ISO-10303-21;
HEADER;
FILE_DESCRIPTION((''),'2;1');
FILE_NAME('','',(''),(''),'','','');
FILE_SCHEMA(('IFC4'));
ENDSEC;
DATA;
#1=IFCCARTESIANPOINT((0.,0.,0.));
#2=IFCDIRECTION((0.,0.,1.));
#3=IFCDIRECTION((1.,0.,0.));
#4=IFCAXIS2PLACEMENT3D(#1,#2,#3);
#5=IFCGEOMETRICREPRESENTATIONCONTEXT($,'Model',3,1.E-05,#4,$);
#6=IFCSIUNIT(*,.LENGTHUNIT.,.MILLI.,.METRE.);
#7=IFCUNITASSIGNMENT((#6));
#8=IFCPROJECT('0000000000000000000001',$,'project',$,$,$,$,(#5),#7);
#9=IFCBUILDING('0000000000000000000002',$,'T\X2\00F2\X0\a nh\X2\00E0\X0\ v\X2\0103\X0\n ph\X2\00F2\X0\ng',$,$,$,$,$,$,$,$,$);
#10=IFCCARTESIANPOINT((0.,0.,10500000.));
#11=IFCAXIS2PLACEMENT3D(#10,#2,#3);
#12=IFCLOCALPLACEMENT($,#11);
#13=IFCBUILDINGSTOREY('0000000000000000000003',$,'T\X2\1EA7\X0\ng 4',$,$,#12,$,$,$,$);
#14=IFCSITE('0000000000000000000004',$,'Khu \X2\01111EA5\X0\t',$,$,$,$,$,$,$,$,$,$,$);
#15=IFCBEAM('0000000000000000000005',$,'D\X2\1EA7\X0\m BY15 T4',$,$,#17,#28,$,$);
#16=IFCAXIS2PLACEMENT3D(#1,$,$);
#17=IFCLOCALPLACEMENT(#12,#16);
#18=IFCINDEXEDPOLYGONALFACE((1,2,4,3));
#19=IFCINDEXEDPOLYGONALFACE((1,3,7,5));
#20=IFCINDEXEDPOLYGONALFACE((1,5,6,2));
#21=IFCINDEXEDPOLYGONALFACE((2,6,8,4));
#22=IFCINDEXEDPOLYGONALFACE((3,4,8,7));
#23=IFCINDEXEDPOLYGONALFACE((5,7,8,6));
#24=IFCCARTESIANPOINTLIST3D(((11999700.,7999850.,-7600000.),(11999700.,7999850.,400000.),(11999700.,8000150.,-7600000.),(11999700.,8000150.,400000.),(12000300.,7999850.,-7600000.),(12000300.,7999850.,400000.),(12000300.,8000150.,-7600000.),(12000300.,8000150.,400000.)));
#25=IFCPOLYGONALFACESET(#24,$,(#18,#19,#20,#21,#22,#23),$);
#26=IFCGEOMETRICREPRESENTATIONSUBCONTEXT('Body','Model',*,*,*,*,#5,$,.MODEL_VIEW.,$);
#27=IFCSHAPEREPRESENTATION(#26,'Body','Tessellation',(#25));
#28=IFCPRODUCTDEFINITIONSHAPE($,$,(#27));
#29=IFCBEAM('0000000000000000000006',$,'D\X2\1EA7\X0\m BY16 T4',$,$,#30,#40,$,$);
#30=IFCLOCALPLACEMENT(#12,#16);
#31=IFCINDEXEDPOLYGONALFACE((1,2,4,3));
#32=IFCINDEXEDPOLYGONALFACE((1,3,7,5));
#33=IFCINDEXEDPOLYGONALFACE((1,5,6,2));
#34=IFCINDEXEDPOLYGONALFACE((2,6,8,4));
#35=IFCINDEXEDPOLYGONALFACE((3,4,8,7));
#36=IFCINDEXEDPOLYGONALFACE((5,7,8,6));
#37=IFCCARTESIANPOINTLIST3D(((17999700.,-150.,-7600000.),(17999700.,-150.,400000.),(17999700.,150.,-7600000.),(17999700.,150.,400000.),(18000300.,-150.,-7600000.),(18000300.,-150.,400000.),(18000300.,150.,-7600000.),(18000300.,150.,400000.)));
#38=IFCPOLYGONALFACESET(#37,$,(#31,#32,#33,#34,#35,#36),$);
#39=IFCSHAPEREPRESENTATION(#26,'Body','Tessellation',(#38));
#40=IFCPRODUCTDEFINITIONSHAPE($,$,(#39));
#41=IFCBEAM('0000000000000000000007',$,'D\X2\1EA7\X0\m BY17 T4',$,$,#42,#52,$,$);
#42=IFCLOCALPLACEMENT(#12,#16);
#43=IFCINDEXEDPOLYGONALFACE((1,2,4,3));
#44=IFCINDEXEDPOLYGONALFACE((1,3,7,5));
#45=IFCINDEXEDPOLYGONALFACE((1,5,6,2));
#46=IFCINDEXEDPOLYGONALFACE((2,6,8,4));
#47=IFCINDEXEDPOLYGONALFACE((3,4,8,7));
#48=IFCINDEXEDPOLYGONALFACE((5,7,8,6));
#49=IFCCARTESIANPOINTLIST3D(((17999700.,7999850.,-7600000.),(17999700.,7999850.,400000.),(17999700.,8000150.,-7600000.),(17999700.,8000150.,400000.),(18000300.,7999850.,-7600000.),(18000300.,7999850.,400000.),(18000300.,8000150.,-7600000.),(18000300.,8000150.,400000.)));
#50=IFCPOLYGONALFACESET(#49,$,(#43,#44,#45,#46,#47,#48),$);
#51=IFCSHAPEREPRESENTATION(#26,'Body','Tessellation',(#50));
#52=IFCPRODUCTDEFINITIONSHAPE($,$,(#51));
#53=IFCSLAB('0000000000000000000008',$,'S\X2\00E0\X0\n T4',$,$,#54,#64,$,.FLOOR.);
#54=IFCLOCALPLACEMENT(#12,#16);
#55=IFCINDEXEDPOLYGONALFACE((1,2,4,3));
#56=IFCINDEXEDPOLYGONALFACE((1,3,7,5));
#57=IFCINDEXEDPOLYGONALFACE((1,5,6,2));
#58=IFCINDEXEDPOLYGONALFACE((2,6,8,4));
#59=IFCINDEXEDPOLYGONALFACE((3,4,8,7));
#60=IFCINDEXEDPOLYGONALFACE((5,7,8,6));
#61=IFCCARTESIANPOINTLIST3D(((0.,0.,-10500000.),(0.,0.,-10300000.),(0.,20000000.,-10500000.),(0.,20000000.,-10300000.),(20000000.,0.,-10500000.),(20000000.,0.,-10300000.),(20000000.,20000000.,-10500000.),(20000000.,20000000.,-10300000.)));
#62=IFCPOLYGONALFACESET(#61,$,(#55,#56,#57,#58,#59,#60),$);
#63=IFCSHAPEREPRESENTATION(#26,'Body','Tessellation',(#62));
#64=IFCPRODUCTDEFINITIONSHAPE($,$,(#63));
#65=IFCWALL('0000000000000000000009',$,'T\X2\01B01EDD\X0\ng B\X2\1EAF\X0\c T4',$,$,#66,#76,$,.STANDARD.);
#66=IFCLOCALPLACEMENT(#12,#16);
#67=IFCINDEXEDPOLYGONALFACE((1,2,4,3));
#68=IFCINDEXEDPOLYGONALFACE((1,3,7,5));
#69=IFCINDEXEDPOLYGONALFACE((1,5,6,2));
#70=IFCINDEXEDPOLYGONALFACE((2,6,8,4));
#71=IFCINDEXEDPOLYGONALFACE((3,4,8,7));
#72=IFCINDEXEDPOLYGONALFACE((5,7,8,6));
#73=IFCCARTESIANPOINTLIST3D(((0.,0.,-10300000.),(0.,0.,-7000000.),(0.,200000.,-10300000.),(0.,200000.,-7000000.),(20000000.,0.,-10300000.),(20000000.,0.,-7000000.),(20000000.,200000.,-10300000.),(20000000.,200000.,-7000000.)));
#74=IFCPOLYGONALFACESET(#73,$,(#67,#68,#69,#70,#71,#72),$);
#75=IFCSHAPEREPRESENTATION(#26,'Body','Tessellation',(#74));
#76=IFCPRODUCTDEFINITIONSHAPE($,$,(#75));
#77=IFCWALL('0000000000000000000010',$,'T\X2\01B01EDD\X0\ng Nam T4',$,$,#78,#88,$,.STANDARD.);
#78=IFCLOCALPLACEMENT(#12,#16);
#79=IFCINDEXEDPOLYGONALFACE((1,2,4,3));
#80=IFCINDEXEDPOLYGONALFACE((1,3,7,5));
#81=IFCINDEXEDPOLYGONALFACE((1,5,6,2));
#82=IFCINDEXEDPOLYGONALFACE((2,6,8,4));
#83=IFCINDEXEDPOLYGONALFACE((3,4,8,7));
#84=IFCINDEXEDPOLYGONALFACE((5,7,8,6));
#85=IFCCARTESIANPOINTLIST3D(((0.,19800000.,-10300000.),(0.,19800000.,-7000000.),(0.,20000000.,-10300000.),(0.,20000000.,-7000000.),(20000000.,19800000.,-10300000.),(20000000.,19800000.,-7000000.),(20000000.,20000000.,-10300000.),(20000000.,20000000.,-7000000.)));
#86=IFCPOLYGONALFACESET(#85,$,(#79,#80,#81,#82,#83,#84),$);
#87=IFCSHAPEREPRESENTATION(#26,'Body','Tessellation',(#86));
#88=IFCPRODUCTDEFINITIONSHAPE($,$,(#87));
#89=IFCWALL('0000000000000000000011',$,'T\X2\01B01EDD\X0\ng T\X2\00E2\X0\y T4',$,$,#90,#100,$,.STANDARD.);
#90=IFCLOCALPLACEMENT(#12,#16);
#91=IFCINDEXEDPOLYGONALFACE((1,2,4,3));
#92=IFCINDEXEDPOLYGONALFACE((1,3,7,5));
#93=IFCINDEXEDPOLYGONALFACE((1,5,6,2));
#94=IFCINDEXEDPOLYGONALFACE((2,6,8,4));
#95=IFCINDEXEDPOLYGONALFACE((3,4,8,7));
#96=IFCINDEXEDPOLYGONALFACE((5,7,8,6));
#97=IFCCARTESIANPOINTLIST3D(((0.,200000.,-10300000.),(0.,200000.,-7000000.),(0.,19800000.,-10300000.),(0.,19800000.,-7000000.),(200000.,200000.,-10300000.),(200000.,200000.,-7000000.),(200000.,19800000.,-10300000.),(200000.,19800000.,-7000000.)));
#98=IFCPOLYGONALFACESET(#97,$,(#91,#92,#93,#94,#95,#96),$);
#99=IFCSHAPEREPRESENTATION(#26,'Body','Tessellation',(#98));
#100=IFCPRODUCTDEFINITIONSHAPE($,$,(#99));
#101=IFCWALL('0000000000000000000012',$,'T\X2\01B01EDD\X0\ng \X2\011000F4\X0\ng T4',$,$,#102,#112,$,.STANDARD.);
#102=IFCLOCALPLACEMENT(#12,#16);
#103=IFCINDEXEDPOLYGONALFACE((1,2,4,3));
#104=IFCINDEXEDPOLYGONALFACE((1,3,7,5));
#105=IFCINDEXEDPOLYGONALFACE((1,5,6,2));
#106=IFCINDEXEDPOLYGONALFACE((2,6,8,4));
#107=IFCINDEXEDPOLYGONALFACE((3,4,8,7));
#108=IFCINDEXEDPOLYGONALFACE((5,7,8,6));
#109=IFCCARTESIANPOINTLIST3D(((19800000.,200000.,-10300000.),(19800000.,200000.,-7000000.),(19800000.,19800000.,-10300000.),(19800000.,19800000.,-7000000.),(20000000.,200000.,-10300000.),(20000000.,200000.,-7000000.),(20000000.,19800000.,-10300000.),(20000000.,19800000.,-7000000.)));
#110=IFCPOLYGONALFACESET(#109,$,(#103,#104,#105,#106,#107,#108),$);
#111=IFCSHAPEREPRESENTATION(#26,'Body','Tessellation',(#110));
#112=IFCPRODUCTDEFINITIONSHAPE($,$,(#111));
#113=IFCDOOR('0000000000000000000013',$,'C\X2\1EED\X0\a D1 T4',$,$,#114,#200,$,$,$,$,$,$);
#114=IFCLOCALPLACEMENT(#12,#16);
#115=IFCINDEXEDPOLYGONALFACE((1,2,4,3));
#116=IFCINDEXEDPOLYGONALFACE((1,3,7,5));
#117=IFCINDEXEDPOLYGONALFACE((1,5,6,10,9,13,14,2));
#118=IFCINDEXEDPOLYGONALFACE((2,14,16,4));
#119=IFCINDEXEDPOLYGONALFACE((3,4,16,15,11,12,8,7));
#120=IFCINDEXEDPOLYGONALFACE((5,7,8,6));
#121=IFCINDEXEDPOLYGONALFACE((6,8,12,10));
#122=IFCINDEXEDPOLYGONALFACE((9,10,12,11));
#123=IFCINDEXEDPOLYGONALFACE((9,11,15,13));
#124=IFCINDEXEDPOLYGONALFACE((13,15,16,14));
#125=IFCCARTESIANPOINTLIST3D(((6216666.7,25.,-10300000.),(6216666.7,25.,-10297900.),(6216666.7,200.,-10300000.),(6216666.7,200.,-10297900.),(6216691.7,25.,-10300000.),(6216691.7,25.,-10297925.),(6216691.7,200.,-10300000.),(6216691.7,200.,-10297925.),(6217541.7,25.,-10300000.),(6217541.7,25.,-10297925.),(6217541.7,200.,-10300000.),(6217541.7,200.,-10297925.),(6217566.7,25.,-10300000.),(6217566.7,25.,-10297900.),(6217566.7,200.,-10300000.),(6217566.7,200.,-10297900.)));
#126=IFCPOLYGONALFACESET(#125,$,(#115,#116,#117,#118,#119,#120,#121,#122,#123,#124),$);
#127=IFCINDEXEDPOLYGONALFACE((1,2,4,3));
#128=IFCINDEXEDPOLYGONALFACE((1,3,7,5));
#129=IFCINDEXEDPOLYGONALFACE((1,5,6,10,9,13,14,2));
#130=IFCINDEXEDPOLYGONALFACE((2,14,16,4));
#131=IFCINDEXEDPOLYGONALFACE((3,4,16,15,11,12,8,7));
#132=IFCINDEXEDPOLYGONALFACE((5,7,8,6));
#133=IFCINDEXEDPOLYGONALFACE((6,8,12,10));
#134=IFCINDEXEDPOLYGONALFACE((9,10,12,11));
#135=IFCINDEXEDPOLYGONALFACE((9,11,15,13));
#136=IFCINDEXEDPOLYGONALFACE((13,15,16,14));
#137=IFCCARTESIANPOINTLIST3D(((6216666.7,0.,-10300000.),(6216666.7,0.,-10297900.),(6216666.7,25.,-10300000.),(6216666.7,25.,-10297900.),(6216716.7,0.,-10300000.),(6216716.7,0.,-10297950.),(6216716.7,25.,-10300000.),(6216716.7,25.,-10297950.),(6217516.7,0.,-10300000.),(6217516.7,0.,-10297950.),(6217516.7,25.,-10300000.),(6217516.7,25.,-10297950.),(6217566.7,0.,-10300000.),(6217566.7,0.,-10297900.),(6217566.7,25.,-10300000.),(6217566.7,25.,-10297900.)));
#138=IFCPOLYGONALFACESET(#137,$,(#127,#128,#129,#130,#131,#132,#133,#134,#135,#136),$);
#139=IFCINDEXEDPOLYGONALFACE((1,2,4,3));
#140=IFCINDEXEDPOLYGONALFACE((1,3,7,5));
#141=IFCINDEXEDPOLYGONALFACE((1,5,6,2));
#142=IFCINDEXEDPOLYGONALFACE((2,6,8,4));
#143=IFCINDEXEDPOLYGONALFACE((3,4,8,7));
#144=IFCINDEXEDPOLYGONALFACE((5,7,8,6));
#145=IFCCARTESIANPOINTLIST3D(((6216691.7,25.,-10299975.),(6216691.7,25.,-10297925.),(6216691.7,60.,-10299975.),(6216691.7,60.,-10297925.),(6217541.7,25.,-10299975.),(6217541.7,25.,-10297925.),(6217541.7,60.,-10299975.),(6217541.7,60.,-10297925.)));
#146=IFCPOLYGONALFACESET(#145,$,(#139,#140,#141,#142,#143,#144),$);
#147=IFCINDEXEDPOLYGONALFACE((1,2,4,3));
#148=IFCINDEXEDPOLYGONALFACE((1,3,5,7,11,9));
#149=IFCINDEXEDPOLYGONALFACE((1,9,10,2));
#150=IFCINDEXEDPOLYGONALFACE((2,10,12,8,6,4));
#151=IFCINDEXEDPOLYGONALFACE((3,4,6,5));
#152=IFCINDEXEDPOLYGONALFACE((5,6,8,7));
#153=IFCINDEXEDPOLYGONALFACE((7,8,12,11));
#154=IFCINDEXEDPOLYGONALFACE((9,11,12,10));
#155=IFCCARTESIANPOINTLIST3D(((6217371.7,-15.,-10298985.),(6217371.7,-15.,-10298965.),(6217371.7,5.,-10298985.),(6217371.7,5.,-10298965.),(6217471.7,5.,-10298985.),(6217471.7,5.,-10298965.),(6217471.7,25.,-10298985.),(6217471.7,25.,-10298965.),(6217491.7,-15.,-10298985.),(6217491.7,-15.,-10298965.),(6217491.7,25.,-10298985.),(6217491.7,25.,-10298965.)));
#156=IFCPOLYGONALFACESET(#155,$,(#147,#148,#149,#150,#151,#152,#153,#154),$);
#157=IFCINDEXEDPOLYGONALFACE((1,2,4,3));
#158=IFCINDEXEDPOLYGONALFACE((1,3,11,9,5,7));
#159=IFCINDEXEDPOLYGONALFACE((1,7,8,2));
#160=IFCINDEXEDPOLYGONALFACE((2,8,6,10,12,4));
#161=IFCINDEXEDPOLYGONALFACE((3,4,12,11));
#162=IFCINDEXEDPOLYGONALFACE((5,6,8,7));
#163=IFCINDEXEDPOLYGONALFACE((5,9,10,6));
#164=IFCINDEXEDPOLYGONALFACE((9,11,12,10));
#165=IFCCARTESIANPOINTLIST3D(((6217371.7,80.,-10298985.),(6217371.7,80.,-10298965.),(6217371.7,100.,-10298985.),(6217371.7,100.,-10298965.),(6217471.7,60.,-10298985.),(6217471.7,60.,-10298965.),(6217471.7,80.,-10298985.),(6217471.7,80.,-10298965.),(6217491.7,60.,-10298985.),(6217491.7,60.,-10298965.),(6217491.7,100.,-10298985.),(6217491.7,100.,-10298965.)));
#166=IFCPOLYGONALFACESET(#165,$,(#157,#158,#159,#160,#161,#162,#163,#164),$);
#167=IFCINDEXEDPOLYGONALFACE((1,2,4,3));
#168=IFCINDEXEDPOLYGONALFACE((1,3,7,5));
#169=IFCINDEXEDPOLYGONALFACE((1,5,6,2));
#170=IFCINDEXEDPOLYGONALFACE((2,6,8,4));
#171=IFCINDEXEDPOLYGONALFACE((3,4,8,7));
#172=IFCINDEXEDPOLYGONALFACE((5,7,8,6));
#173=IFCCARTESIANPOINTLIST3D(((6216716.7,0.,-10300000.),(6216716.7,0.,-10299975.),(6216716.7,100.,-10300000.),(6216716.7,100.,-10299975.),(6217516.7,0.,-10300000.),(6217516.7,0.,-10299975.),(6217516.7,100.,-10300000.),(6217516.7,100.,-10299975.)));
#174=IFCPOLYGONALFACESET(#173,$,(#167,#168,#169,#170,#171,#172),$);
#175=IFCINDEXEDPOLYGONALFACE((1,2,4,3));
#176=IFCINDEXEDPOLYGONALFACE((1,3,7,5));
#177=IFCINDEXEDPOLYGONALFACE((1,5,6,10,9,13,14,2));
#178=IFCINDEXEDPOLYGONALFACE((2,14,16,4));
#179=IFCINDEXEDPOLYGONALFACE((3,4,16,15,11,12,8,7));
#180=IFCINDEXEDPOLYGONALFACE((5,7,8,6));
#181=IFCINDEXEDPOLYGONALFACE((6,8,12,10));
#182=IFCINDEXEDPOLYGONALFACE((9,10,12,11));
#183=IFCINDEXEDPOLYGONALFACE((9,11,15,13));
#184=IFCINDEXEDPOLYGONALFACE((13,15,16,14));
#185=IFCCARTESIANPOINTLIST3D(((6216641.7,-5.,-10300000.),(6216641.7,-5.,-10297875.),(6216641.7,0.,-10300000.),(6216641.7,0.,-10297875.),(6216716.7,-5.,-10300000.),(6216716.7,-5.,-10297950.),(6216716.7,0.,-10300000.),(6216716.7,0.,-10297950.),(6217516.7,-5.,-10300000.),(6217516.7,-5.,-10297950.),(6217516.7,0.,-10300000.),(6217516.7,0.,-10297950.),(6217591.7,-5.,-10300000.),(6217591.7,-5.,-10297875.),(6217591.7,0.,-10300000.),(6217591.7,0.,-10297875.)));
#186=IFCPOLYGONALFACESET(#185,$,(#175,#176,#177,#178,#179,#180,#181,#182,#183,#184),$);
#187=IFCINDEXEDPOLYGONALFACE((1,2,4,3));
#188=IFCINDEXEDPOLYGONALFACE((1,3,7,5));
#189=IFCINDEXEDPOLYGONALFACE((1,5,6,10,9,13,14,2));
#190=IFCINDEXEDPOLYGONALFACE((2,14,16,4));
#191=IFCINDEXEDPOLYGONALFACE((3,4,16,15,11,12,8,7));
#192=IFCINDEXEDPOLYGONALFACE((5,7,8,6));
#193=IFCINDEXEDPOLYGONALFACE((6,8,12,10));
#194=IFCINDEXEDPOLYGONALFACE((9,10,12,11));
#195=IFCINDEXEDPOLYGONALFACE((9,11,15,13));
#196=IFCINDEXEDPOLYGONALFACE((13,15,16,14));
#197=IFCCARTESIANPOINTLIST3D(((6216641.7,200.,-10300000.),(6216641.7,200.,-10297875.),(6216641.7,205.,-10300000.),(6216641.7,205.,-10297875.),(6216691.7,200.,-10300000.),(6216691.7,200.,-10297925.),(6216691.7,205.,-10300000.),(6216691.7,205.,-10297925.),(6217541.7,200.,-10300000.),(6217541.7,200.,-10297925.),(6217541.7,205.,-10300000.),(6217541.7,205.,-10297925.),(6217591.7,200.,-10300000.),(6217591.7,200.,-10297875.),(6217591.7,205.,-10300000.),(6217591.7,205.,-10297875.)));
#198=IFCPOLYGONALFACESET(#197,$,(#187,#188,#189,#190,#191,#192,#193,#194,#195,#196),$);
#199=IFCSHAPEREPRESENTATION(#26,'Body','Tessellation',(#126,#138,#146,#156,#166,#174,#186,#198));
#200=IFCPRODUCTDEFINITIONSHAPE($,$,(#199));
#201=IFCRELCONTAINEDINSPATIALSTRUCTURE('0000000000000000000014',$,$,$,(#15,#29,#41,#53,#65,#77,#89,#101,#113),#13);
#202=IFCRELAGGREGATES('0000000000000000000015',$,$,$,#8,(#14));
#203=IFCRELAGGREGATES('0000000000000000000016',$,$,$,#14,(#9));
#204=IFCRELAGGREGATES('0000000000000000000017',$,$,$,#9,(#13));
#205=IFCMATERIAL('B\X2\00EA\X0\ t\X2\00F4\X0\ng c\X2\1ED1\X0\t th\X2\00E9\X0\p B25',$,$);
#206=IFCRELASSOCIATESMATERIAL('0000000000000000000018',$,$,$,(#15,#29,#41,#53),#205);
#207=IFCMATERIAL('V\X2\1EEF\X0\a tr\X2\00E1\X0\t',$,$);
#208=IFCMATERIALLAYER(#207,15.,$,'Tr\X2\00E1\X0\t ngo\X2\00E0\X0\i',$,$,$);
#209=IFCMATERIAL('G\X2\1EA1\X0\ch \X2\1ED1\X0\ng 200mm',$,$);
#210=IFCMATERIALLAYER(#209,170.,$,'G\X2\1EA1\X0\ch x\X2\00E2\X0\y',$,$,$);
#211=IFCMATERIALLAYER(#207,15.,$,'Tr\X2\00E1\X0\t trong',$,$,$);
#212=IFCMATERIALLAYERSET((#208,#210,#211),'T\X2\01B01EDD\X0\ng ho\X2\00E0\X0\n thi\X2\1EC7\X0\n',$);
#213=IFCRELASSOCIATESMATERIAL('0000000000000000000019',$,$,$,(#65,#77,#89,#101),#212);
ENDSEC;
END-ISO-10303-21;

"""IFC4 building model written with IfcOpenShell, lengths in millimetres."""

from ifc_helpers import new_model, entity, si_unit, frame, origin_with_axes, place, context, subcontext, project, spatial, line, indexed_curve, outline, extrude, material, layer, layer_set, layer_usage, element, save


model = new_model("IFC4")

# Units and contexts
model_context = context("Model", 3, precision=1e-05, world=origin_with_axes())
body_context = subcontext(model_context, "Body", "Model", "MODEL_VIEW")
ifc_project = project(units=[si_unit("LENGTHUNIT", "METRE", prefix="MILLI")], contexts=[model_context])

# Site, building, storey
site = spatial("IfcSite", under=ifc_project, Name="Khu đất")
building = spatial("IfcBuilding", under=site, Name="Tòa nhà văn phòng")
storey_placement = place(None, frame((0.0, 0.0, 10500000.0), z_axis=(0.0, 0.0, 1.0), x_axis=(1.0, 0.0, 0.0)))
storey = spatial("IfcBuildingStorey", under=building, at=storey_placement, Name="Tầng 4")

# Shared definitions
ifc_material_1 = material(Name="Bê tông cốt thép B25")

# Beams
for number, where, z_axis, x_axis, name in (
    (1, (12000000.0, 8000000.0, -7600000.0), (0.0, 0.0, 1.0), (0.0, 1.0, 0.0), "Dầm BY15 T4"),
    (2, (18000000.0, 0.0, -7600000.0), (0.0, 0.0, 1.0), (0.0, 1.0, 0.0), "Dầm BY16 T4"),
    (3, (18000000.0, 8000000.0, -7600000.0), (0.0, 0.0, 1.0), (0.0, 1.0, 0.0), "Dầm BY17 T4"),
):
    element("IfcBeam", number, at=place(storey_placement, frame(where, z_axis=z_axis, x_axis=x_axis)), inside=storey, material=ifc_material_1, Name=name, context=body_context, shape_type="SweptSolid", body=[
        extrude(entity("IfcRectangleProfileDef", None, None, None, 300.0, 600.0), origin_with_axes(), (0.0, 0.0, 1.0), 8000000.0),
    ])

# Slab
slab_placement = place(storey_placement, frame((0.0, 0.0, -10500000.0), z_axis=(0.0, 0.0, 1.0), x_axis=(1.0, 0.0, 0.0)))
element("IfcSlab", 4, at=slab_placement, inside=storey, material=ifc_material_1, Name="Sàn T4", PredefinedType="FLOOR", context=body_context, shape_type="SweptSolid", body=[
    extrude(outline(indexed_curve([(0.0, 0.0), (20000000.0, 0.0), (20000000.0, 20000000.0), (0.0, 20000000.0), (0.0, 0.0)])), None, (0.0, 0.0, 1.0), 200000.0),
])

# Walls
ifc_material_2 = material(Name="Vữa trát")
ifc_layer_1 = layer(ifc_material_2, 15.0, Name="Trát ngoài")
ifc_material_3 = material(Name="Gạch ống 200mm")
ifc_layer_2 = layer(ifc_material_3, 170.0, Name="Gạch xây")
ifc_layer_3 = layer(ifc_material_2, 15.0, Name="Trát trong")
ifc_layer_set = layer_set([ifc_layer_1, ifc_layer_2, ifc_layer_3], Name="Tường hoàn thiện")
ifc_layer_usage_1 = layer_usage(ifc_layer_set, "AXIS2", "POSITIVE", 0.0)
wall_1_placement = place(storey_placement, frame((0.0, 0.0, -10300000.0), z_axis=(0.0, 0.0, 1.0), x_axis=(1.0, 0.0, 0.0)))
element("IfcWall", 5, at=wall_1_placement, inside=storey, material=ifc_layer_usage_1, Name="Tường Bắc T4", PredefinedType="STANDARD", context=body_context, shape_type="SweptSolid", body=[
    extrude(outline(indexed_curve([(0.0, 0.0), (0.0, 200000.0), (20000000.0, 200000.0), (20000000.0, 0.0), (0.0, 0.0)], self_intersect=False)), origin_with_axes(), (0.0, 0.0, 1.0), 3300000.0),
])
ifc_layer_usage_2 = layer_usage(ifc_layer_set, "AXIS2", "POSITIVE", 0.0)
wall_2_placement = place(storey_placement, frame((0.0, 19800000.0, -10300000.0), z_axis=(0.0, 0.0, 1.0), x_axis=(1.0, 0.0, 0.0)))
element("IfcWall", 6, at=wall_2_placement, inside=storey, material=ifc_layer_usage_2, Name="Tường Nam T4", PredefinedType="STANDARD", context=body_context, shape_type="SweptSolid", body=[
    extrude(outline(indexed_curve([(0.0, 0.0), (0.0, 200000.0), (20000000.0, 200000.0), (20000000.0, 0.0), (0.0, 0.0)], self_intersect=False)), origin_with_axes(), (0.0, 0.0, 1.0), 3300000.0),
])
ifc_layer_usage_3 = layer_usage(ifc_layer_set, "AXIS2", "POSITIVE", 0.0)
wall_3_placement = place(storey_placement, frame((0.0, 200000.0, -10300000.0), z_axis=(0.0, 0.0, 1.0), x_axis=(1.0, 0.0, 0.0)))
element("IfcWall", 7, at=wall_3_placement, inside=storey, material=ifc_layer_usage_3, Name="Tường Tây T4", PredefinedType="STANDARD", context=body_context, shape_type="SweptSolid", body=[
    extrude(outline(indexed_curve([(0.0, 0.0), (0.0, 19600000.0), (200000.0, 19600000.0), (200000.0, 0.0), (0.0, 0.0)], self_intersect=False)), origin_with_axes(), (0.0, 0.0, 1.0), 3300000.0),
])
ifc_layer_usage_4 = layer_usage(ifc_layer_set, "AXIS2", "POSITIVE", 0.0)
wall_4_placement = place(storey_placement, frame((19800000.0, 200000.0, -10300000.0), z_axis=(0.0, 0.0, 1.0), x_axis=(1.0, 0.0, 0.0)))
element("IfcWall", 8, at=wall_4_placement, inside=storey, material=ifc_layer_usage_4, Name="Tường Đông T4", PredefinedType="STANDARD", context=body_context, shape_type="SweptSolid", body=[
    extrude(outline(indexed_curve([(0.0, 0.0), (0.0, 19600000.0), (200000.0, 19600000.0), (200000.0, 0.0), (0.0, 0.0)], self_intersect=False)), origin_with_axes(), (0.0, 0.0, 1.0), 3300000.0),
])

# Door
door_1_placement = place(storey_placement, frame((6216666.7, 0.0, -10300000.0), z_axis=(0.0, 0.0, 1.0), x_axis=(1.0, 0.0, 0.0)))
element("IfcDoor", 9, at=door_1_placement, inside=storey, Name="Cửa D1 T4", context=body_context, shape_type="SolidModel", body=[
    extrude(outline(indexed_curve([(0.0, 0.0), (0.0, 2100.0), (900.0, 2100.0), (900.0, 0.0), (875.0, 0.0), (875.0, 2075.0), (25.0, 2075.0), (25.0, 0.0)], segments=[line(1, 2, 3, 4, 5, 6, 7, 8, 1)])), frame((0.0, 25.0, 0.0), z_axis=(0.0, -1.0, 0.0), x_axis=(1.0, 0.0, 0.0)), (0.0, 0.0, -1.0), 175.0),
    extrude(outline(indexed_curve([(0.0, 0.0), (0.0, 2100.0), (900.0, 2100.0), (900.0, 0.0), (850.0, 0.0), (850.0, 2050.0), (50.0, 2050.0), (50.0, 0.0)], segments=[line(1, 2, 3, 4, 5, 6, 7, 8, 1)])), frame((0.0, 0.0, 0.0), z_axis=(0.0, -1.0, 0.0), x_axis=(1.0, 0.0, 0.0)), (0.0, 0.0, -1.0), 25.0),
    extrude(outline(indexed_curve([(0.0, 0.0), (850.0, 0.0), (850.0, 35.0), (0.0, 35.0)], segments=[line(1, 2, 3, 4, 1)])), frame((25.0, 25.0, 25.0), z_axis=(0.0, 0.0, 1.0), x_axis=(1.0, 0.0, 0.0)), (0.0, 0.0, 1.0), 2050.0),
    extrude(outline(indexed_curve([(0.0, 0.0), (0.0, -40.0), (-120.0, -40.0), (-120.0, -20.0), (-20.0, -20.0), (-20.0, 0.0)], segments=[line(1, 2, 3, 4, 5, 6, 1)])), frame((825.0, 25.0, 1015.0), z_axis=(0.0, 0.0, 1.0), x_axis=(1.0, 0.0, 0.0)), (0.0, 0.0, 1.0), 20.0),
    extrude(outline(indexed_curve([(0.0, 0.0), (0.0, 40.0), (-120.0, 40.0), (-120.0, 20.0), (-20.0, 20.0), (-20.0, 0.0)], segments=[line(1, 2, 3, 4, 5, 6, 1)])), frame((825.0, 60.0, 1015.0), z_axis=(0.0, 0.0, 1.0), x_axis=(1.0, 0.0, 0.0)), (0.0, 0.0, 1.0), 20.0),
    extrude(outline(indexed_curve([(0.0, 0.0), (800.0, 0.0), (800.0, 100.0), (0.0, 100.0)], segments=[line(1, 2, 3, 4, 1)])), frame((50.0, 0.0, 0.0), z_axis=(0.0, 0.0, 1.0), x_axis=(1.0, 0.0, 0.0)), (0.0, 0.0, 1.0), 25.0),
    extrude(outline(indexed_curve([(0.0, 0.0), (0.0, 2125.0), (950.0, 2125.0), (950.0, 0.0), (875.0, 0.0), (875.0, 2050.0), (75.0, 2050.0), (75.0, 0.0)], segments=[line(1, 2, 3, 4, 5, 6, 7, 8, 1)])), frame((-25.0, -5.0, 0.0), z_axis=(0.0, -1.0, 0.0), x_axis=(1.0, 0.0, 0.0)), (0.0, 0.0, -1.0), 5.0),
    extrude(outline(indexed_curve([(0.0, 0.0), (0.0, 2125.0), (950.0, 2125.0), (950.0, 0.0), (900.0, 0.0), (900.0, 2075.0), (50.0, 2075.0), (50.0, 0.0)], segments=[line(1, 2, 3, 4, 5, 6, 7, 8, 1)])), frame((-25.0, 200.0, 0.0), z_axis=(0.0, -1.0, 0.0), x_axis=(1.0, 0.0, 0.0)), (0.0, 0.0, -1.0), 5.0),
])

save(model, "model.ifc")
